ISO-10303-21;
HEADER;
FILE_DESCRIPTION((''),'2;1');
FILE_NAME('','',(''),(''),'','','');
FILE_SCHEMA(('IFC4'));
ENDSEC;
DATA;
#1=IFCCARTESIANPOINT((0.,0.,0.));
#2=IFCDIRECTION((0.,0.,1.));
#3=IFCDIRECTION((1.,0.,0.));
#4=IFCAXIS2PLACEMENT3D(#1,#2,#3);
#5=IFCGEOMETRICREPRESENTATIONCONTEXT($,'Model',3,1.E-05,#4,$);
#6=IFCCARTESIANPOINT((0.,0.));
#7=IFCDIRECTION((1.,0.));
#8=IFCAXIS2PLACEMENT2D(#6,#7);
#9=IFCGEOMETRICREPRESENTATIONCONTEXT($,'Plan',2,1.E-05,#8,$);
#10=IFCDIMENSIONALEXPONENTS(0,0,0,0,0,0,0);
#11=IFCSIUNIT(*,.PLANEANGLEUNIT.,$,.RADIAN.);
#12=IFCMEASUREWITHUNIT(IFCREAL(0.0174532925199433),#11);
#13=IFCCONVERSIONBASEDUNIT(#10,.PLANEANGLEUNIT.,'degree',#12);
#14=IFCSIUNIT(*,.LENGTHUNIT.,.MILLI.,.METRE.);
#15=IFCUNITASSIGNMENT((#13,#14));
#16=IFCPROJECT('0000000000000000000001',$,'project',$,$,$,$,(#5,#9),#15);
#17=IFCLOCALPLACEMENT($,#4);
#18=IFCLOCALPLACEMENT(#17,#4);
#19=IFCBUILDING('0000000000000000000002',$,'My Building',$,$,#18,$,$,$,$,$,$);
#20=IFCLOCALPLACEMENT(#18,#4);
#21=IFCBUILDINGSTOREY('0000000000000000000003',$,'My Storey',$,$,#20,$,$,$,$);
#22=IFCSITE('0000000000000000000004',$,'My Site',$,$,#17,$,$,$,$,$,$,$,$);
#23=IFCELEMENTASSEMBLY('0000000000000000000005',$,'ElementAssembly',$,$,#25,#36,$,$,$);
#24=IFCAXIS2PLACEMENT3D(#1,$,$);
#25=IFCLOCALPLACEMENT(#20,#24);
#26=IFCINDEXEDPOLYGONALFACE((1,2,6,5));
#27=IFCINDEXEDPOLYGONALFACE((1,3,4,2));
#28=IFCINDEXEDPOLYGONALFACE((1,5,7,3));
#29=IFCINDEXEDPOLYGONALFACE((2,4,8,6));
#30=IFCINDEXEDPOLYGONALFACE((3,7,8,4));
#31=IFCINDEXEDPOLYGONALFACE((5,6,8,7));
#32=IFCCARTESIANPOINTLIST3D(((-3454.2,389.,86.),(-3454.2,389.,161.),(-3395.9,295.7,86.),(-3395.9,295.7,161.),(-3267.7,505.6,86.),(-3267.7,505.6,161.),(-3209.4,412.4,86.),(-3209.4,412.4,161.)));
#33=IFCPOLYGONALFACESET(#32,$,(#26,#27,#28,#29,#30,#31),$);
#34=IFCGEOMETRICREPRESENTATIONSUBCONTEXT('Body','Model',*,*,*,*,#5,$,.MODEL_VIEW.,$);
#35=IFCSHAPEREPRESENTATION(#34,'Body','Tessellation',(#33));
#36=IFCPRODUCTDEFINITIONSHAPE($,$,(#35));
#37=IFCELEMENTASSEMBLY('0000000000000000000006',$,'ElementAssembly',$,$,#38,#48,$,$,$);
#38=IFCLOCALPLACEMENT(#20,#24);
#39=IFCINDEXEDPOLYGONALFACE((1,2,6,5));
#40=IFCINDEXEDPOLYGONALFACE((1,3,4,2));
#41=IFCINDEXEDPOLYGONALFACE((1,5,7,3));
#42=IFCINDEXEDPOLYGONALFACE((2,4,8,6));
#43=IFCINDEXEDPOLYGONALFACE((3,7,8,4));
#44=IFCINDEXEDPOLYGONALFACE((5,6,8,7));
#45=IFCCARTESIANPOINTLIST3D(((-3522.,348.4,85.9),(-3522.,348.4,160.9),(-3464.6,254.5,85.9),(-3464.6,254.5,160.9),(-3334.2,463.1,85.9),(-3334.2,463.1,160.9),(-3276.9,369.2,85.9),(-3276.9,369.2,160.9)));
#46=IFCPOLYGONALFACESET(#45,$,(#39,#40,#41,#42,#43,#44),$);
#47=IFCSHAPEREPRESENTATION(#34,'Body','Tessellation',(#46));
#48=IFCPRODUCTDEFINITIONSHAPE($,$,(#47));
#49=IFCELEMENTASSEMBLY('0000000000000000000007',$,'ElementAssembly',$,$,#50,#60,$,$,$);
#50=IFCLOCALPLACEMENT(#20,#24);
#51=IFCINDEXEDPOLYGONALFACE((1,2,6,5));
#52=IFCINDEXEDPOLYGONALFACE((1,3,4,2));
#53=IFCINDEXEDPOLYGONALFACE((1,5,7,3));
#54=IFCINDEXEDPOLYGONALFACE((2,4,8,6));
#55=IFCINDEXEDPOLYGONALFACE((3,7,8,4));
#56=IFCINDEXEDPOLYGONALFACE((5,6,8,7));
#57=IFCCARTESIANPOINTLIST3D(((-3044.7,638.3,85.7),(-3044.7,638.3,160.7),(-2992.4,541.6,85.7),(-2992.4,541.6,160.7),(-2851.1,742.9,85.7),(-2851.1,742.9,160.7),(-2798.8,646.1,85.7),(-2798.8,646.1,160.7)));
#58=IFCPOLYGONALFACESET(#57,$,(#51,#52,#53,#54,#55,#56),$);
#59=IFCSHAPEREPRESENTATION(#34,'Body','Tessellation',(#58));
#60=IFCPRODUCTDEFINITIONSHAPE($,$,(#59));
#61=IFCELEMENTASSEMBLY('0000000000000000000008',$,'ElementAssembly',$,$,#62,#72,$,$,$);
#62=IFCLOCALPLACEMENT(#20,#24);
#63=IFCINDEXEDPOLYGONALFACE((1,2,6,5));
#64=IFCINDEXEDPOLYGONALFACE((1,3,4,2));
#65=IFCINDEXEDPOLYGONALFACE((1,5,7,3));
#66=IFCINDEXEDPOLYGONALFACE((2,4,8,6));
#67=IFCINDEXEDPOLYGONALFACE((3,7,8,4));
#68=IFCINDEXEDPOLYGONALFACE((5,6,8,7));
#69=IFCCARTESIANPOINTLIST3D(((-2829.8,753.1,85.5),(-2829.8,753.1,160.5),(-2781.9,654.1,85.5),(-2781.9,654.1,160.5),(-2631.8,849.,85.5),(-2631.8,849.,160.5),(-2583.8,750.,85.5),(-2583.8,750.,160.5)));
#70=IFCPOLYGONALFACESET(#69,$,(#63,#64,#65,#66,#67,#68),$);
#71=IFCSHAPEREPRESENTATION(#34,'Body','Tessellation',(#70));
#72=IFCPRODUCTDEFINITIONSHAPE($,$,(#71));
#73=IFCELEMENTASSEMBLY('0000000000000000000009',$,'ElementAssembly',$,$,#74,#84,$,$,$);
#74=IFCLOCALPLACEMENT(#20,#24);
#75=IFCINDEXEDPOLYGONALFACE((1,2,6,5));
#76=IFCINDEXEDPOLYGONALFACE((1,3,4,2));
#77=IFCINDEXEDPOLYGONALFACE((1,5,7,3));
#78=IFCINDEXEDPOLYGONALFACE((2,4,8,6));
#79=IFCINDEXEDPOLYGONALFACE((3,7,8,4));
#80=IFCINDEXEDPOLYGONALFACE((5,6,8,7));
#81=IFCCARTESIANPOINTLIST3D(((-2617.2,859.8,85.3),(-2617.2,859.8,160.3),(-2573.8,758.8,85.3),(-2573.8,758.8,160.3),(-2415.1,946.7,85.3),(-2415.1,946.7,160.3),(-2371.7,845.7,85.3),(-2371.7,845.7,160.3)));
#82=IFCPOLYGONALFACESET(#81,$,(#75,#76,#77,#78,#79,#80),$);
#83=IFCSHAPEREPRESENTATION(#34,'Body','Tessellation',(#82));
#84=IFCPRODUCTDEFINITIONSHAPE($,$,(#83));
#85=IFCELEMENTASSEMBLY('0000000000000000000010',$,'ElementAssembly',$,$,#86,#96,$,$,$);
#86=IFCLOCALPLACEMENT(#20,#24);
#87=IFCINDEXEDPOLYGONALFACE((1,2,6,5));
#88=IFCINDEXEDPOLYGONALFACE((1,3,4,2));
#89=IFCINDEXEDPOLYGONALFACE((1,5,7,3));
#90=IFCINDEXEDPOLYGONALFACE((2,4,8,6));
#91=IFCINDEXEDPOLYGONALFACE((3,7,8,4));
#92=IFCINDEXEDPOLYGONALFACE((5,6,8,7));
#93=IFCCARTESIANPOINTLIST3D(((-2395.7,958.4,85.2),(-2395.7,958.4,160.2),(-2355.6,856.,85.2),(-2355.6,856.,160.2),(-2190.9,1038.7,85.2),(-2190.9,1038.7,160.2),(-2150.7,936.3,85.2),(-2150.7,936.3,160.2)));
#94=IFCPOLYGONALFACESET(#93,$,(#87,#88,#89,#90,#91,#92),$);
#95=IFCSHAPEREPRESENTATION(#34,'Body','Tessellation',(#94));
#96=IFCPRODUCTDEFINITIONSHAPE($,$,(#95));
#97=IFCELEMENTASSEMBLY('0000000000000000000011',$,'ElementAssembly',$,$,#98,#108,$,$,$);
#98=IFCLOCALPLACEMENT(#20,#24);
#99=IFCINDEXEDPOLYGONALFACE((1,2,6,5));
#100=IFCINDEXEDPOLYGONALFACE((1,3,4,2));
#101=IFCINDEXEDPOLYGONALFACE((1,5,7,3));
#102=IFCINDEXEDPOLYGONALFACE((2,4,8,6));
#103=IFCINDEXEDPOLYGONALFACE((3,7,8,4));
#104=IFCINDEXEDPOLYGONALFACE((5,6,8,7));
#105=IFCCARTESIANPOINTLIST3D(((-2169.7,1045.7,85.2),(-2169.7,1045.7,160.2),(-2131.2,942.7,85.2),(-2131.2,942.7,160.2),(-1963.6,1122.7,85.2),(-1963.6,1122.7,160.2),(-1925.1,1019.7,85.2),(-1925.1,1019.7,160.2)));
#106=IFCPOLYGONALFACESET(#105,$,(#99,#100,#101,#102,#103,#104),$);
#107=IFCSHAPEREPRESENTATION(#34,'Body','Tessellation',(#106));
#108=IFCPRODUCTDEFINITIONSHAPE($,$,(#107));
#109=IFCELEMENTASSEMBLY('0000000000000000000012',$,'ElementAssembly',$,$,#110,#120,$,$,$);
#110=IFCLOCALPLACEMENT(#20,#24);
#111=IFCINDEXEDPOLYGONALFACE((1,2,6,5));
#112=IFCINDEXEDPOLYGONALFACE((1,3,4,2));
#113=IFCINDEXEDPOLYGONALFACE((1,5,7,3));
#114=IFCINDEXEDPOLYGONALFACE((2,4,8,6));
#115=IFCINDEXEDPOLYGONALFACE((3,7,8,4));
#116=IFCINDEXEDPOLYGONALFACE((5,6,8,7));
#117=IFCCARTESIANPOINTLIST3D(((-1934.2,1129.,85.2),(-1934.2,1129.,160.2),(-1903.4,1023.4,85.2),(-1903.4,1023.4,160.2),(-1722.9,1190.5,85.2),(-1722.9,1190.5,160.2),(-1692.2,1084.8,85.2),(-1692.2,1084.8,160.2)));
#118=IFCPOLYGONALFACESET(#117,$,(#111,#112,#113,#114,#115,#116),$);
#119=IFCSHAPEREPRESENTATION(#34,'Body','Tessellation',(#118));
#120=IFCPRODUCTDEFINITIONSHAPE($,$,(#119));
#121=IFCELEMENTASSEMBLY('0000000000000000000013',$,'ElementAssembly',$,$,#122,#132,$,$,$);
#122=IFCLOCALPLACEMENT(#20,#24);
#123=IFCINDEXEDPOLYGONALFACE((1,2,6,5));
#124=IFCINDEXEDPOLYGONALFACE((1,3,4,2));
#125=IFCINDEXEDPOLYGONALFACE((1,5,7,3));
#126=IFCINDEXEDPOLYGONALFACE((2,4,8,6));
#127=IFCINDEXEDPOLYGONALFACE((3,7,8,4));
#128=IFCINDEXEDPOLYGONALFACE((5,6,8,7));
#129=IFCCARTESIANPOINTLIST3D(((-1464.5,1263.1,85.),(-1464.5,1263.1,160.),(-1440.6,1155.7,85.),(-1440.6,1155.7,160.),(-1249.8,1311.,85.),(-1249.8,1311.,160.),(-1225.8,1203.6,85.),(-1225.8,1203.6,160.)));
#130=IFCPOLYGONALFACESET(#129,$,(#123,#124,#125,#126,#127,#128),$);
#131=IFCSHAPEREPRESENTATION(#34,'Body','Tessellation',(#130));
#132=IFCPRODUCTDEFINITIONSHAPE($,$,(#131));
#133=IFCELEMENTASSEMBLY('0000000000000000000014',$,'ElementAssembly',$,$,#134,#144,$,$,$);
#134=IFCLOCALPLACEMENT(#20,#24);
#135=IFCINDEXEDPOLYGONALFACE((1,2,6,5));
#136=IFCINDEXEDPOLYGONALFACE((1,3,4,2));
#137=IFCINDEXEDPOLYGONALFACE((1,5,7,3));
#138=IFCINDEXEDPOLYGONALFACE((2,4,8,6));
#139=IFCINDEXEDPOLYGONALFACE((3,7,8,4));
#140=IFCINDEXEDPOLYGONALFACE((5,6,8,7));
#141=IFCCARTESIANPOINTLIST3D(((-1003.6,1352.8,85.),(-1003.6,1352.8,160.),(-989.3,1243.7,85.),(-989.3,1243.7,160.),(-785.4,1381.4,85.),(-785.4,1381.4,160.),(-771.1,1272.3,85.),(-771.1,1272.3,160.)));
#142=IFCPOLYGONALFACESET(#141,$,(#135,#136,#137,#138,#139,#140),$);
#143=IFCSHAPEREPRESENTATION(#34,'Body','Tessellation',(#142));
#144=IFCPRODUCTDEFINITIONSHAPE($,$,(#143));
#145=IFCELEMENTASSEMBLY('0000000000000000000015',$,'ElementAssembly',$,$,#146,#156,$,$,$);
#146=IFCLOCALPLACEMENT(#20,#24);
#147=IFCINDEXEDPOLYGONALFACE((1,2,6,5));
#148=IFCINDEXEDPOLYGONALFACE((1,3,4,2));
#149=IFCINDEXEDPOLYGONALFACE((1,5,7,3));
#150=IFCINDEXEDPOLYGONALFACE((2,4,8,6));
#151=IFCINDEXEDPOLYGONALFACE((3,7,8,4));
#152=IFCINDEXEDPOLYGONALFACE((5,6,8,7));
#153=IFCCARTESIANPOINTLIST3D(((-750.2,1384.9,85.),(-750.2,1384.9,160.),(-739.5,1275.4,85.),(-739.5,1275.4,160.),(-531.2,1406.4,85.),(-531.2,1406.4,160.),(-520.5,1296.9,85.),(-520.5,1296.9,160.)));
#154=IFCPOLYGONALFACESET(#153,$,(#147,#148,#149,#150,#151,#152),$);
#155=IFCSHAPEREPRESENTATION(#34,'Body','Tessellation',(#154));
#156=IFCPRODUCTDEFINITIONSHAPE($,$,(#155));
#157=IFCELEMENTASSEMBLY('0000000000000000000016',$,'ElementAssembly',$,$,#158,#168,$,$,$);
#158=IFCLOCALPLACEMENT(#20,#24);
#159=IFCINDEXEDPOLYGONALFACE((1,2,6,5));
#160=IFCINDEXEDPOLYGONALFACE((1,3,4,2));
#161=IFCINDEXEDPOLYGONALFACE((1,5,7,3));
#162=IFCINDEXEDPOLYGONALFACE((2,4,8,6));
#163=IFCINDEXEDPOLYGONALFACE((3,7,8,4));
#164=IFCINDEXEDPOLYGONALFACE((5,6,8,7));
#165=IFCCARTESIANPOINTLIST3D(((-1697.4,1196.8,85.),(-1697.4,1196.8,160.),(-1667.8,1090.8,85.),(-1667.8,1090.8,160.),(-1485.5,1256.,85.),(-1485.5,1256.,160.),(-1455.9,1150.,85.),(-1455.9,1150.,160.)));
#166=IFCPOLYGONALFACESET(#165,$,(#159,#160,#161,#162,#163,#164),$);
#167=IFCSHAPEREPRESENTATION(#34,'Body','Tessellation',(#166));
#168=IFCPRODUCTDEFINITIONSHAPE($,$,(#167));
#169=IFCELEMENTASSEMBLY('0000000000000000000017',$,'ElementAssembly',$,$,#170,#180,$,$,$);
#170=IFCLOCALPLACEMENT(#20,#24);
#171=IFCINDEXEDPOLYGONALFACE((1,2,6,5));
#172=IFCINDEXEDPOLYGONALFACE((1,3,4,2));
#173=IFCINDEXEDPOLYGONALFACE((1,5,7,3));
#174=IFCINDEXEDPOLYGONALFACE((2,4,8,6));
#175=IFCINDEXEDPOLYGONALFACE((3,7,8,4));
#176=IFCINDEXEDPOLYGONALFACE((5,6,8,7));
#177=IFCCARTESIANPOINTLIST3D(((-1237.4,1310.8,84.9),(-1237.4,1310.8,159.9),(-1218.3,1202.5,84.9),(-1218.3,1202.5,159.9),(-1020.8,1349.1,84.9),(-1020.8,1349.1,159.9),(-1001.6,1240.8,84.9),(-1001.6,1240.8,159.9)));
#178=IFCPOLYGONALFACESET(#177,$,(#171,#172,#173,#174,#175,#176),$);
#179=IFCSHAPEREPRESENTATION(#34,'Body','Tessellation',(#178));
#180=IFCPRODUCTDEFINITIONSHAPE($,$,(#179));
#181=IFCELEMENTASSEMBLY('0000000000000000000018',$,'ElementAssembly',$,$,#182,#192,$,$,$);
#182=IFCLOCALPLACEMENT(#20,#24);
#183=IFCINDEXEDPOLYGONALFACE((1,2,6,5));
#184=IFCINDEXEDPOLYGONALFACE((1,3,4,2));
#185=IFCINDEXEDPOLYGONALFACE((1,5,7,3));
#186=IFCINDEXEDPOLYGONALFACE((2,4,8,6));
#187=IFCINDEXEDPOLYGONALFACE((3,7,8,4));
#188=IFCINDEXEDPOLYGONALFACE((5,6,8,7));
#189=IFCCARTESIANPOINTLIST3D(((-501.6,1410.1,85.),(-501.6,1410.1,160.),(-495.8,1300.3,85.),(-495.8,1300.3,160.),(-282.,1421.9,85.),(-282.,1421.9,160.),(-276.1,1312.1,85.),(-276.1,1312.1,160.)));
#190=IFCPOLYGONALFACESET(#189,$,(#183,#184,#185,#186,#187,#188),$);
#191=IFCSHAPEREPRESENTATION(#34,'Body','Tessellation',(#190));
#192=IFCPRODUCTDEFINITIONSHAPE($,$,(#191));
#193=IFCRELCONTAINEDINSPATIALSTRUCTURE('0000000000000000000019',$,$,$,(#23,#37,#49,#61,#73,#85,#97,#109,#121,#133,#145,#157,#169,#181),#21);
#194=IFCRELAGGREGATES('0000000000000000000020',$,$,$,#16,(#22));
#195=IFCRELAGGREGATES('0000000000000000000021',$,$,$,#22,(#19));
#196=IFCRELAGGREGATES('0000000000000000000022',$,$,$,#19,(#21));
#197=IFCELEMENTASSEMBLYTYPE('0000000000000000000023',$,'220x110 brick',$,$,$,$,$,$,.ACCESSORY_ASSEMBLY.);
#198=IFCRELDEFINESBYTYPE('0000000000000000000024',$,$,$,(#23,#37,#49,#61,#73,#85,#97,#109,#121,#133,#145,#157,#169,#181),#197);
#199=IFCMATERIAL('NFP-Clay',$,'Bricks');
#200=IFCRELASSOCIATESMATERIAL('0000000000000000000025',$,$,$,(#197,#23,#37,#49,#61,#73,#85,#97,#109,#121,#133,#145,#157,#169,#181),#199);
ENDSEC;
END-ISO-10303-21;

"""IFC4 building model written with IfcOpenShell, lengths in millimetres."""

from ifc_helpers import new_model, entity, si_unit, converted_unit, frame, origin_with_axes, origin_2d_with_axis, place, context, subcontext, project, spatial, rectangle, extrude, material, material_profile, profile_set, profile_usage, type_object, element, save


model = new_model("IFC4")

# Units and contexts
model_context = context("Model", 3, precision=1e-05, world=origin_with_axes())
plan_context = context("Plan", 2, precision=1e-05, world=origin_2d_with_axis())
body_context = subcontext(model_context, "Body", "Model", "MODEL_VIEW")
ifc_project = project(units=[converted_unit("PLANEANGLEUNIT", "degree", entity("IfcReal", 0.0174532925199433), si_unit("PLANEANGLEUNIT", "RADIAN"), dimensions=[0, 0, 0, 0, 0, 0, 0]), si_unit("LENGTHUNIT", "METRE", prefix="MILLI")], contexts=[model_context, plan_context])

# Site, building, storey
site_placement = place(None, origin_with_axes())
site = spatial("IfcSite", under=ifc_project, at=site_placement, Name="My Site")
building_placement = place(site_placement, origin_with_axes())
building = spatial("IfcBuilding", under=site, at=building_placement, Name="My Building")
storey_placement = place(building_placement, origin_with_axes())
storey = spatial("IfcBuildingStorey", under=building, at=storey_placement, Name="My Storey")

# Element assemblies
ifc_material = material(Name="NFP-Clay", Category="Bricks")
ifc_material_profile = material_profile(ifc_material, rectangle(XDim=220.0, YDim=110.0))
ifc_profile_set = profile_set([ifc_material_profile])
ifc_profile_usage_1 = profile_usage(ifc_profile_set, cardinal=5)
element_assembly_type = type_object("IfcElementAssemblyType", Name="220x110 brick", PredefinedType="ACCESSORY_ASSEMBLY", material=ifc_profile_set)
assembly_1_placement = place(storey_placement, frame((-3331.8, 400.7, 86.0), z_axis=(0.0, 0.0, 1.0), x_axis=(0.847878, 0.530192, 0.0)))
element("IfcElementAssembly", 1, at=assembly_1_placement, inside=storey, type_object=element_assembly_type, material=ifc_profile_usage_1, Name="ElementAssembly", context=body_context, shape_type="SweptSolid", body=[
    extrude(rectangle(XDim=220.0, YDim=110.0), origin_with_axes(), (0.0, 0.0, 1.0), 75.0),
])
ifc_profile_usage_2 = profile_usage(ifc_profile_set, cardinal=5)
assembly_2_placement = place(storey_placement, frame((-3399.4, 358.8, 85.9), z_axis=(0.0, 0.0, 1.0), x_axis=(0.853485, 0.521117, 0.0)))
element("IfcElementAssembly", 2, at=assembly_2_placement, inside=storey, type_object=element_assembly_type, material=ifc_profile_usage_2, Name="ElementAssembly", context=body_context, shape_type="SweptSolid", body=[
    extrude(rectangle(XDim=220.0, YDim=110.0), origin_with_axes(), (0.0, 0.0, 1.0), 75.0),
])
ifc_profile_usage_3 = profile_usage(ifc_profile_set, cardinal=5)
assembly_3_placement = place(storey_placement, frame((-2921.8, 642.2, 85.7), z_axis=(0.0, 0.0, 1.0), x_axis=(0.879847, 0.475257, 0.0)))
element("IfcElementAssembly", 3, at=assembly_3_placement, inside=storey, type_object=element_assembly_type, material=ifc_profile_usage_3, Name="ElementAssembly", context=body_context, shape_type="SweptSolid", body=[
    extrude(rectangle(XDim=220.0, YDim=110.0), origin_with_axes(), (0.0, 0.0, 1.0), 75.0),
])
ifc_profile_usage_4 = profile_usage(ifc_profile_set, cardinal=5)
assembly_4_placement = place(storey_placement, frame((-2706.8, 751.5, 85.5), z_axis=(0.0, 0.0, 1.0), x_axis=(0.900086, 0.435712, 0.0)))
element("IfcElementAssembly", 4, at=assembly_4_placement, inside=storey, type_object=element_assembly_type, material=ifc_profile_usage_4, Name="ElementAssembly", context=body_context, shape_type="SweptSolid", body=[
    extrude(rectangle(XDim=220.0, YDim=110.0), origin_with_axes(), (0.0, 0.0, 1.0), 75.0),
])
ifc_profile_usage_5 = profile_usage(ifc_profile_set, cardinal=5)
assembly_5_placement = place(storey_placement, frame((-2494.4, 852.7, 85.3), z_axis=(0.0, 0.0, 1.0), x_axis=(0.918638, 0.395101, 0.0)))
element("IfcElementAssembly", 5, at=assembly_5_placement, inside=storey, type_object=element_assembly_type, material=ifc_profile_usage_5, Name="ElementAssembly", context=body_context, shape_type="SweptSolid", body=[
    extrude(rectangle(XDim=220.0, YDim=110.0), origin_with_axes(), (0.0, 0.0, 1.0), 75.0),
])
ifc_profile_usage_6 = profile_usage(ifc_profile_set, cardinal=5)
assembly_6_placement = place(storey_placement, frame((-2273.2, 947.4, 85.2), z_axis=(0.0, 0.0, 1.0), x_axis=(0.931044, 0.364907, 0.0)))
element("IfcElementAssembly", 6, at=assembly_6_placement, inside=storey, type_object=element_assembly_type, material=ifc_profile_usage_6, Name="ElementAssembly", context=body_context, shape_type="SweptSolid", body=[
    extrude(rectangle(XDim=220.0, YDim=110.0), origin_with_axes(), (0.0, 0.0, 1.0), 75.0),
])
ifc_profile_usage_7 = profile_usage(ifc_profile_set, cardinal=5)
assembly_7_placement = place(storey_placement, frame((-2047.4, 1032.7, 85.2), z_axis=(0.0, 0.0, 1.0), x_axis=(0.936764, 0.349962, 0.0)))
element("IfcElementAssembly", 7, at=assembly_7_placement, inside=storey, type_object=element_assembly_type, material=ifc_profile_usage_7, Name="ElementAssembly", context=body_context, shape_type="SweptSolid", body=[
    extrude(rectangle(XDim=220.0, YDim=110.0), origin_with_axes(), (0.0, 0.0, 1.0), 75.0),
])
ifc_profile_usage_8 = profile_usage(ifc_profile_set, cardinal=5)
assembly_8_placement = place(storey_placement, frame((-1813.2, 1106.9, 85.2), z_axis=(0.0, 0.0, 1.0), x_axis=(0.960191, 0.279343, 0.0)))
element("IfcElementAssembly", 8, at=assembly_8_placement, inside=storey, type_object=element_assembly_type, material=ifc_profile_usage_8, Name="ElementAssembly", context=body_context, shape_type="SweptSolid", body=[
    extrude(rectangle(XDim=220.0, YDim=110.0), origin_with_axes(), (0.0, 0.0, 1.0), 75.0),
])
ifc_profile_usage_9 = profile_usage(ifc_profile_set, cardinal=5)
assembly_9_placement = place(storey_placement, frame((-1345.2, 1233.4, 85.0), z_axis=(0.0, 0.0, 1.0), x_axis=(0.975998, 0.21778, 0.0)))
element("IfcElementAssembly", 9, at=assembly_9_placement, inside=storey, type_object=element_assembly_type, material=ifc_profile_usage_9, Name="ElementAssembly", context=body_context, shape_type="SweptSolid", body=[
    extrude(rectangle(XDim=220.0, YDim=110.0), origin_with_axes(), (0.0, 0.0, 1.0), 75.0),
])
ifc_profile_usage_10 = profile_usage(ifc_profile_set, cardinal=5)
assembly_10_placement = place(storey_placement, frame((-887.3, 1312.6, 85.0), z_axis=(0.0, 0.0, 1.0), x_axis=(0.991502, 0.13009, 0.0)))
element("IfcElementAssembly", 10, at=assembly_10_placement, inside=storey, type_object=element_assembly_type, material=ifc_profile_usage_10, Name="ElementAssembly", context=body_context, shape_type="SweptSolid", body=[
    extrude(rectangle(XDim=220.0, YDim=110.0), origin_with_axes(), (0.0, 0.0, 1.0), 75.0),
])
ifc_profile_usage_11 = profile_usage(ifc_profile_set, cardinal=5)
assembly_11_placement = place(storey_placement, frame((-635.3, 1340.9, 85.0), z_axis=(0.0, 0.0, 1.0), x_axis=(0.99522, 0.09766, 0.0)))
element("IfcElementAssembly", 11, at=assembly_11_placement, inside=storey, type_object=element_assembly_type, material=ifc_profile_usage_11, Name="ElementAssembly", context=body_context, shape_type="SweptSolid", body=[
    extrude(rectangle(XDim=220.0, YDim=110.0), origin_with_axes(), (0.0, 0.0, 1.0), 75.0),
])
ifc_profile_usage_12 = profile_usage(ifc_profile_set, cardinal=5)
assembly_12_placement = place(storey_placement, frame((-1576.7, 1173.4, 85.0), z_axis=(0.0, 0.0, 1.0), x_axis=(0.963117, 0.269084, 0.0)))
element("IfcElementAssembly", 12, at=assembly_12_placement, inside=storey, type_object=element_assembly_type, material=ifc_profile_usage_12, Name="ElementAssembly", context=body_context, shape_type="SweptSolid", body=[
    extrude(rectangle(XDim=220.0, YDim=110.0), origin_with_axes(), (0.0, 0.0, 1.0), 75.0),
])
ifc_profile_usage_13 = profile_usage(ifc_profile_set, cardinal=5)
assembly_13_placement = place(storey_placement, frame((-1119.5, 1275.8, 84.9), z_axis=(0.0, 0.0, 1.0), x_axis=(0.984707, 0.174219, 0.0)))
element("IfcElementAssembly", 13, at=assembly_13_placement, inside=storey, type_object=element_assembly_type, material=ifc_profile_usage_13, Name="ElementAssembly", context=body_context, shape_type="SweptSolid", body=[
    extrude(rectangle(XDim=220.0, YDim=110.0), origin_with_axes(), (0.0, 0.0, 1.0), 75.0),
])
ifc_profile_usage_14 = profile_usage(ifc_profile_set, cardinal=5)
assembly_14_placement = place(storey_placement, frame((-388.9, 1361.1, 85.0), z_axis=(0.0, 0.0, 1.0), x_axis=(0.998565, 0.053551, 0.0)))
element("IfcElementAssembly", 14, at=assembly_14_placement, inside=storey, type_object=element_assembly_type, material=ifc_profile_usage_14, Name="ElementAssembly", context=body_context, shape_type="SweptSolid", body=[
    extrude(rectangle(XDim=220.0, YDim=110.0), origin_with_axes(), (0.0, 0.0, 1.0), 75.0),
])

save(model, "model.ifc")
